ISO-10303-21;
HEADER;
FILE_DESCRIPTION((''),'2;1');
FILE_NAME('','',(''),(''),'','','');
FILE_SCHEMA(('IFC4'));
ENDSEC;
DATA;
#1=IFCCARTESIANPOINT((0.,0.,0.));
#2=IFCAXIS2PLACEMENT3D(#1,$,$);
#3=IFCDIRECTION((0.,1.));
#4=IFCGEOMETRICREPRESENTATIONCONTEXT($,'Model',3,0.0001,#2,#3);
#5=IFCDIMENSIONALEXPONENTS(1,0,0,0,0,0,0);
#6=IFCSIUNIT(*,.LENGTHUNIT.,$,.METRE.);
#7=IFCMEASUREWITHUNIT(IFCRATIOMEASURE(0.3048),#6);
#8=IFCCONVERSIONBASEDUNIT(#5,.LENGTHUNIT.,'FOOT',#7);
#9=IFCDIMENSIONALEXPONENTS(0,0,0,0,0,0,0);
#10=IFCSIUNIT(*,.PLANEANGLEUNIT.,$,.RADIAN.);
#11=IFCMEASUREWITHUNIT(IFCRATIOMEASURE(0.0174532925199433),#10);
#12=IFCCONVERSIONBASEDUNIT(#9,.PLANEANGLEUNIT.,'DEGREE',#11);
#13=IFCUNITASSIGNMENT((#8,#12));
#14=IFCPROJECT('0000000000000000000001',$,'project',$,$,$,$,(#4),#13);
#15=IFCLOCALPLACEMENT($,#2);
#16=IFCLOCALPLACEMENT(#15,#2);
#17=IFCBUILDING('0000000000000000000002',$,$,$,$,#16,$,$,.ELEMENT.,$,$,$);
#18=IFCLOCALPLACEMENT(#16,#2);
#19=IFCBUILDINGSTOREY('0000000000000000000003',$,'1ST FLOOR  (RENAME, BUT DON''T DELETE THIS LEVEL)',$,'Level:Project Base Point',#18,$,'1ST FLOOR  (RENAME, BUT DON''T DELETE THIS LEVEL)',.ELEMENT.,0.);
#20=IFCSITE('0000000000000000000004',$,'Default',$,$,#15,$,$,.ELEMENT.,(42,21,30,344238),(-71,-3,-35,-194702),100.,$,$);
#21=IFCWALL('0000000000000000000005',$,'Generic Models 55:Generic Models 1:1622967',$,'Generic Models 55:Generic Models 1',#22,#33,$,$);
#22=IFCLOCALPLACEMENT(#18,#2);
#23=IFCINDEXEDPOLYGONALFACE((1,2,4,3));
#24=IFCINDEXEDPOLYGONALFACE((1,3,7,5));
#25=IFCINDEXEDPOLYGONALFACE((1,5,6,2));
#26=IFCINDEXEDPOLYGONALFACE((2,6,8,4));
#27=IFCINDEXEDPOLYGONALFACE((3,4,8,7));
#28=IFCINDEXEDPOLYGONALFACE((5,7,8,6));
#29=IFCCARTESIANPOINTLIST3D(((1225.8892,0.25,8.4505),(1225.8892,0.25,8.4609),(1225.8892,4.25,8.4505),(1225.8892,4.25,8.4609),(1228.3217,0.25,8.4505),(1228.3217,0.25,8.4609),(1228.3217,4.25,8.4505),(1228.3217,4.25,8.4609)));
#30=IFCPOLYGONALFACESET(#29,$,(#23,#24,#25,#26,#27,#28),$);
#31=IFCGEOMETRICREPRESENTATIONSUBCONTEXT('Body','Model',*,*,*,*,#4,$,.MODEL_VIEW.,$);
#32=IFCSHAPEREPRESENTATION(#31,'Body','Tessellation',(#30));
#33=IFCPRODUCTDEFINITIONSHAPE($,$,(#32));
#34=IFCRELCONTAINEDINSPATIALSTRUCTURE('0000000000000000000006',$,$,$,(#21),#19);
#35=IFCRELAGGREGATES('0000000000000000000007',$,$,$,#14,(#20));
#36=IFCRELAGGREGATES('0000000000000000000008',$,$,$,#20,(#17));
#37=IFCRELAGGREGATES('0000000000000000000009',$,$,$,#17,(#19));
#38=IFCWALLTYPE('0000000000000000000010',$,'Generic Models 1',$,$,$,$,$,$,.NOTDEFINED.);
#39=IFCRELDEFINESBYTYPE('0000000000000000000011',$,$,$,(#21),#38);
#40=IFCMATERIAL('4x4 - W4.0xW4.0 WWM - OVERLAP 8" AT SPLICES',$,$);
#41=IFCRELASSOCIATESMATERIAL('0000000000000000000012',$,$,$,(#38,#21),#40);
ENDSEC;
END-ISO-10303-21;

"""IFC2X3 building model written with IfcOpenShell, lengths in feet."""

from ifc_helpers import new_model, entity, si_unit, converted_unit, direction, frame, frame_2d, origin, place, context, subcontext, project, spatial, rectangle, extrude, material, type_object, element, save


model = new_model("IFC2X3")

# Units and contexts
model_context = context("Model", 3, precision=0.0001, world=origin(), true_north=direction((0.0, 1.0)))
body_context = subcontext(model_context, "Body", "Model", "MODEL_VIEW")
ifc_project = project(units=[converted_unit("LENGTHUNIT", "FOOT", entity("IfcRatioMeasure", 0.3048), si_unit("LENGTHUNIT", "METRE"), dimensions=[1, 0, 0, 0, 0, 0, 0]), converted_unit("PLANEANGLEUNIT", "DEGREE", entity("IfcRatioMeasure", 0.0174532925199433), si_unit("PLANEANGLEUNIT", "RADIAN"), dimensions=[0, 0, 0, 0, 0, 0, 0])], contexts=[model_context])

# Site, building, storey
site_placement = place(None, origin())
site = spatial("IfcSite", under=ifc_project, at=site_placement, Name="Default", CompositionType="ELEMENT", RefLatitude=(42, 21, 30, 344238), RefLongitude=(-71, -3, -35, -194702), RefElevation=100.0)
building_placement = place(site_placement, origin())
building = spatial("IfcBuilding", under=site, at=building_placement, CompositionType="ELEMENT")
storey_placement = place(building_placement, origin())
storey = spatial("IfcBuildingStorey", under=building, at=storey_placement, Name="1ST FLOOR  (RENAME, BUT DON'T DELETE THIS LEVEL)", ObjectType="Level:Project Base Point", LongName="1ST FLOOR  (RENAME, BUT DON'T DELETE THIS LEVEL)", CompositionType="ELEMENT", Elevation=0.0)

# Wall
ifc_material_1 = material(Name="4x4 - W4.0xW4.0 WWM - OVERLAP 8\" AT SPLICES")
wall_type_1 = type_object("IfcWallType", Name="Generic Models 1", PredefinedType="NOTDEFINED", material=ifc_material_1)
wall_1_placement = place(storey_placement, frame((1225.8892, 0.25, 8.4505), z_axis=(0.0, 0.0, 1.0), x_axis=(0.0, 1.0, 0.0)))
element("IfcWall", 1, at=wall_1_placement, inside=storey, type_object=wall_type_1, material=ifc_material_1, Name="Generic Models 55:Generic Models 1:1622967", ObjectType="Generic Models 55:Generic Models 1", context=body_context, shape_type="SweptSolid", body=[
    extrude(rectangle(XDim=4.0, YDim=2.4325, at=frame_2d((0.0, 0.0), x_axis=(1.0, 0.0))), frame((2.0, -1.2162, 0.0)), (0.0, 0.0, 1.0), 0.0104),
])

save(model, "model.ifc")
